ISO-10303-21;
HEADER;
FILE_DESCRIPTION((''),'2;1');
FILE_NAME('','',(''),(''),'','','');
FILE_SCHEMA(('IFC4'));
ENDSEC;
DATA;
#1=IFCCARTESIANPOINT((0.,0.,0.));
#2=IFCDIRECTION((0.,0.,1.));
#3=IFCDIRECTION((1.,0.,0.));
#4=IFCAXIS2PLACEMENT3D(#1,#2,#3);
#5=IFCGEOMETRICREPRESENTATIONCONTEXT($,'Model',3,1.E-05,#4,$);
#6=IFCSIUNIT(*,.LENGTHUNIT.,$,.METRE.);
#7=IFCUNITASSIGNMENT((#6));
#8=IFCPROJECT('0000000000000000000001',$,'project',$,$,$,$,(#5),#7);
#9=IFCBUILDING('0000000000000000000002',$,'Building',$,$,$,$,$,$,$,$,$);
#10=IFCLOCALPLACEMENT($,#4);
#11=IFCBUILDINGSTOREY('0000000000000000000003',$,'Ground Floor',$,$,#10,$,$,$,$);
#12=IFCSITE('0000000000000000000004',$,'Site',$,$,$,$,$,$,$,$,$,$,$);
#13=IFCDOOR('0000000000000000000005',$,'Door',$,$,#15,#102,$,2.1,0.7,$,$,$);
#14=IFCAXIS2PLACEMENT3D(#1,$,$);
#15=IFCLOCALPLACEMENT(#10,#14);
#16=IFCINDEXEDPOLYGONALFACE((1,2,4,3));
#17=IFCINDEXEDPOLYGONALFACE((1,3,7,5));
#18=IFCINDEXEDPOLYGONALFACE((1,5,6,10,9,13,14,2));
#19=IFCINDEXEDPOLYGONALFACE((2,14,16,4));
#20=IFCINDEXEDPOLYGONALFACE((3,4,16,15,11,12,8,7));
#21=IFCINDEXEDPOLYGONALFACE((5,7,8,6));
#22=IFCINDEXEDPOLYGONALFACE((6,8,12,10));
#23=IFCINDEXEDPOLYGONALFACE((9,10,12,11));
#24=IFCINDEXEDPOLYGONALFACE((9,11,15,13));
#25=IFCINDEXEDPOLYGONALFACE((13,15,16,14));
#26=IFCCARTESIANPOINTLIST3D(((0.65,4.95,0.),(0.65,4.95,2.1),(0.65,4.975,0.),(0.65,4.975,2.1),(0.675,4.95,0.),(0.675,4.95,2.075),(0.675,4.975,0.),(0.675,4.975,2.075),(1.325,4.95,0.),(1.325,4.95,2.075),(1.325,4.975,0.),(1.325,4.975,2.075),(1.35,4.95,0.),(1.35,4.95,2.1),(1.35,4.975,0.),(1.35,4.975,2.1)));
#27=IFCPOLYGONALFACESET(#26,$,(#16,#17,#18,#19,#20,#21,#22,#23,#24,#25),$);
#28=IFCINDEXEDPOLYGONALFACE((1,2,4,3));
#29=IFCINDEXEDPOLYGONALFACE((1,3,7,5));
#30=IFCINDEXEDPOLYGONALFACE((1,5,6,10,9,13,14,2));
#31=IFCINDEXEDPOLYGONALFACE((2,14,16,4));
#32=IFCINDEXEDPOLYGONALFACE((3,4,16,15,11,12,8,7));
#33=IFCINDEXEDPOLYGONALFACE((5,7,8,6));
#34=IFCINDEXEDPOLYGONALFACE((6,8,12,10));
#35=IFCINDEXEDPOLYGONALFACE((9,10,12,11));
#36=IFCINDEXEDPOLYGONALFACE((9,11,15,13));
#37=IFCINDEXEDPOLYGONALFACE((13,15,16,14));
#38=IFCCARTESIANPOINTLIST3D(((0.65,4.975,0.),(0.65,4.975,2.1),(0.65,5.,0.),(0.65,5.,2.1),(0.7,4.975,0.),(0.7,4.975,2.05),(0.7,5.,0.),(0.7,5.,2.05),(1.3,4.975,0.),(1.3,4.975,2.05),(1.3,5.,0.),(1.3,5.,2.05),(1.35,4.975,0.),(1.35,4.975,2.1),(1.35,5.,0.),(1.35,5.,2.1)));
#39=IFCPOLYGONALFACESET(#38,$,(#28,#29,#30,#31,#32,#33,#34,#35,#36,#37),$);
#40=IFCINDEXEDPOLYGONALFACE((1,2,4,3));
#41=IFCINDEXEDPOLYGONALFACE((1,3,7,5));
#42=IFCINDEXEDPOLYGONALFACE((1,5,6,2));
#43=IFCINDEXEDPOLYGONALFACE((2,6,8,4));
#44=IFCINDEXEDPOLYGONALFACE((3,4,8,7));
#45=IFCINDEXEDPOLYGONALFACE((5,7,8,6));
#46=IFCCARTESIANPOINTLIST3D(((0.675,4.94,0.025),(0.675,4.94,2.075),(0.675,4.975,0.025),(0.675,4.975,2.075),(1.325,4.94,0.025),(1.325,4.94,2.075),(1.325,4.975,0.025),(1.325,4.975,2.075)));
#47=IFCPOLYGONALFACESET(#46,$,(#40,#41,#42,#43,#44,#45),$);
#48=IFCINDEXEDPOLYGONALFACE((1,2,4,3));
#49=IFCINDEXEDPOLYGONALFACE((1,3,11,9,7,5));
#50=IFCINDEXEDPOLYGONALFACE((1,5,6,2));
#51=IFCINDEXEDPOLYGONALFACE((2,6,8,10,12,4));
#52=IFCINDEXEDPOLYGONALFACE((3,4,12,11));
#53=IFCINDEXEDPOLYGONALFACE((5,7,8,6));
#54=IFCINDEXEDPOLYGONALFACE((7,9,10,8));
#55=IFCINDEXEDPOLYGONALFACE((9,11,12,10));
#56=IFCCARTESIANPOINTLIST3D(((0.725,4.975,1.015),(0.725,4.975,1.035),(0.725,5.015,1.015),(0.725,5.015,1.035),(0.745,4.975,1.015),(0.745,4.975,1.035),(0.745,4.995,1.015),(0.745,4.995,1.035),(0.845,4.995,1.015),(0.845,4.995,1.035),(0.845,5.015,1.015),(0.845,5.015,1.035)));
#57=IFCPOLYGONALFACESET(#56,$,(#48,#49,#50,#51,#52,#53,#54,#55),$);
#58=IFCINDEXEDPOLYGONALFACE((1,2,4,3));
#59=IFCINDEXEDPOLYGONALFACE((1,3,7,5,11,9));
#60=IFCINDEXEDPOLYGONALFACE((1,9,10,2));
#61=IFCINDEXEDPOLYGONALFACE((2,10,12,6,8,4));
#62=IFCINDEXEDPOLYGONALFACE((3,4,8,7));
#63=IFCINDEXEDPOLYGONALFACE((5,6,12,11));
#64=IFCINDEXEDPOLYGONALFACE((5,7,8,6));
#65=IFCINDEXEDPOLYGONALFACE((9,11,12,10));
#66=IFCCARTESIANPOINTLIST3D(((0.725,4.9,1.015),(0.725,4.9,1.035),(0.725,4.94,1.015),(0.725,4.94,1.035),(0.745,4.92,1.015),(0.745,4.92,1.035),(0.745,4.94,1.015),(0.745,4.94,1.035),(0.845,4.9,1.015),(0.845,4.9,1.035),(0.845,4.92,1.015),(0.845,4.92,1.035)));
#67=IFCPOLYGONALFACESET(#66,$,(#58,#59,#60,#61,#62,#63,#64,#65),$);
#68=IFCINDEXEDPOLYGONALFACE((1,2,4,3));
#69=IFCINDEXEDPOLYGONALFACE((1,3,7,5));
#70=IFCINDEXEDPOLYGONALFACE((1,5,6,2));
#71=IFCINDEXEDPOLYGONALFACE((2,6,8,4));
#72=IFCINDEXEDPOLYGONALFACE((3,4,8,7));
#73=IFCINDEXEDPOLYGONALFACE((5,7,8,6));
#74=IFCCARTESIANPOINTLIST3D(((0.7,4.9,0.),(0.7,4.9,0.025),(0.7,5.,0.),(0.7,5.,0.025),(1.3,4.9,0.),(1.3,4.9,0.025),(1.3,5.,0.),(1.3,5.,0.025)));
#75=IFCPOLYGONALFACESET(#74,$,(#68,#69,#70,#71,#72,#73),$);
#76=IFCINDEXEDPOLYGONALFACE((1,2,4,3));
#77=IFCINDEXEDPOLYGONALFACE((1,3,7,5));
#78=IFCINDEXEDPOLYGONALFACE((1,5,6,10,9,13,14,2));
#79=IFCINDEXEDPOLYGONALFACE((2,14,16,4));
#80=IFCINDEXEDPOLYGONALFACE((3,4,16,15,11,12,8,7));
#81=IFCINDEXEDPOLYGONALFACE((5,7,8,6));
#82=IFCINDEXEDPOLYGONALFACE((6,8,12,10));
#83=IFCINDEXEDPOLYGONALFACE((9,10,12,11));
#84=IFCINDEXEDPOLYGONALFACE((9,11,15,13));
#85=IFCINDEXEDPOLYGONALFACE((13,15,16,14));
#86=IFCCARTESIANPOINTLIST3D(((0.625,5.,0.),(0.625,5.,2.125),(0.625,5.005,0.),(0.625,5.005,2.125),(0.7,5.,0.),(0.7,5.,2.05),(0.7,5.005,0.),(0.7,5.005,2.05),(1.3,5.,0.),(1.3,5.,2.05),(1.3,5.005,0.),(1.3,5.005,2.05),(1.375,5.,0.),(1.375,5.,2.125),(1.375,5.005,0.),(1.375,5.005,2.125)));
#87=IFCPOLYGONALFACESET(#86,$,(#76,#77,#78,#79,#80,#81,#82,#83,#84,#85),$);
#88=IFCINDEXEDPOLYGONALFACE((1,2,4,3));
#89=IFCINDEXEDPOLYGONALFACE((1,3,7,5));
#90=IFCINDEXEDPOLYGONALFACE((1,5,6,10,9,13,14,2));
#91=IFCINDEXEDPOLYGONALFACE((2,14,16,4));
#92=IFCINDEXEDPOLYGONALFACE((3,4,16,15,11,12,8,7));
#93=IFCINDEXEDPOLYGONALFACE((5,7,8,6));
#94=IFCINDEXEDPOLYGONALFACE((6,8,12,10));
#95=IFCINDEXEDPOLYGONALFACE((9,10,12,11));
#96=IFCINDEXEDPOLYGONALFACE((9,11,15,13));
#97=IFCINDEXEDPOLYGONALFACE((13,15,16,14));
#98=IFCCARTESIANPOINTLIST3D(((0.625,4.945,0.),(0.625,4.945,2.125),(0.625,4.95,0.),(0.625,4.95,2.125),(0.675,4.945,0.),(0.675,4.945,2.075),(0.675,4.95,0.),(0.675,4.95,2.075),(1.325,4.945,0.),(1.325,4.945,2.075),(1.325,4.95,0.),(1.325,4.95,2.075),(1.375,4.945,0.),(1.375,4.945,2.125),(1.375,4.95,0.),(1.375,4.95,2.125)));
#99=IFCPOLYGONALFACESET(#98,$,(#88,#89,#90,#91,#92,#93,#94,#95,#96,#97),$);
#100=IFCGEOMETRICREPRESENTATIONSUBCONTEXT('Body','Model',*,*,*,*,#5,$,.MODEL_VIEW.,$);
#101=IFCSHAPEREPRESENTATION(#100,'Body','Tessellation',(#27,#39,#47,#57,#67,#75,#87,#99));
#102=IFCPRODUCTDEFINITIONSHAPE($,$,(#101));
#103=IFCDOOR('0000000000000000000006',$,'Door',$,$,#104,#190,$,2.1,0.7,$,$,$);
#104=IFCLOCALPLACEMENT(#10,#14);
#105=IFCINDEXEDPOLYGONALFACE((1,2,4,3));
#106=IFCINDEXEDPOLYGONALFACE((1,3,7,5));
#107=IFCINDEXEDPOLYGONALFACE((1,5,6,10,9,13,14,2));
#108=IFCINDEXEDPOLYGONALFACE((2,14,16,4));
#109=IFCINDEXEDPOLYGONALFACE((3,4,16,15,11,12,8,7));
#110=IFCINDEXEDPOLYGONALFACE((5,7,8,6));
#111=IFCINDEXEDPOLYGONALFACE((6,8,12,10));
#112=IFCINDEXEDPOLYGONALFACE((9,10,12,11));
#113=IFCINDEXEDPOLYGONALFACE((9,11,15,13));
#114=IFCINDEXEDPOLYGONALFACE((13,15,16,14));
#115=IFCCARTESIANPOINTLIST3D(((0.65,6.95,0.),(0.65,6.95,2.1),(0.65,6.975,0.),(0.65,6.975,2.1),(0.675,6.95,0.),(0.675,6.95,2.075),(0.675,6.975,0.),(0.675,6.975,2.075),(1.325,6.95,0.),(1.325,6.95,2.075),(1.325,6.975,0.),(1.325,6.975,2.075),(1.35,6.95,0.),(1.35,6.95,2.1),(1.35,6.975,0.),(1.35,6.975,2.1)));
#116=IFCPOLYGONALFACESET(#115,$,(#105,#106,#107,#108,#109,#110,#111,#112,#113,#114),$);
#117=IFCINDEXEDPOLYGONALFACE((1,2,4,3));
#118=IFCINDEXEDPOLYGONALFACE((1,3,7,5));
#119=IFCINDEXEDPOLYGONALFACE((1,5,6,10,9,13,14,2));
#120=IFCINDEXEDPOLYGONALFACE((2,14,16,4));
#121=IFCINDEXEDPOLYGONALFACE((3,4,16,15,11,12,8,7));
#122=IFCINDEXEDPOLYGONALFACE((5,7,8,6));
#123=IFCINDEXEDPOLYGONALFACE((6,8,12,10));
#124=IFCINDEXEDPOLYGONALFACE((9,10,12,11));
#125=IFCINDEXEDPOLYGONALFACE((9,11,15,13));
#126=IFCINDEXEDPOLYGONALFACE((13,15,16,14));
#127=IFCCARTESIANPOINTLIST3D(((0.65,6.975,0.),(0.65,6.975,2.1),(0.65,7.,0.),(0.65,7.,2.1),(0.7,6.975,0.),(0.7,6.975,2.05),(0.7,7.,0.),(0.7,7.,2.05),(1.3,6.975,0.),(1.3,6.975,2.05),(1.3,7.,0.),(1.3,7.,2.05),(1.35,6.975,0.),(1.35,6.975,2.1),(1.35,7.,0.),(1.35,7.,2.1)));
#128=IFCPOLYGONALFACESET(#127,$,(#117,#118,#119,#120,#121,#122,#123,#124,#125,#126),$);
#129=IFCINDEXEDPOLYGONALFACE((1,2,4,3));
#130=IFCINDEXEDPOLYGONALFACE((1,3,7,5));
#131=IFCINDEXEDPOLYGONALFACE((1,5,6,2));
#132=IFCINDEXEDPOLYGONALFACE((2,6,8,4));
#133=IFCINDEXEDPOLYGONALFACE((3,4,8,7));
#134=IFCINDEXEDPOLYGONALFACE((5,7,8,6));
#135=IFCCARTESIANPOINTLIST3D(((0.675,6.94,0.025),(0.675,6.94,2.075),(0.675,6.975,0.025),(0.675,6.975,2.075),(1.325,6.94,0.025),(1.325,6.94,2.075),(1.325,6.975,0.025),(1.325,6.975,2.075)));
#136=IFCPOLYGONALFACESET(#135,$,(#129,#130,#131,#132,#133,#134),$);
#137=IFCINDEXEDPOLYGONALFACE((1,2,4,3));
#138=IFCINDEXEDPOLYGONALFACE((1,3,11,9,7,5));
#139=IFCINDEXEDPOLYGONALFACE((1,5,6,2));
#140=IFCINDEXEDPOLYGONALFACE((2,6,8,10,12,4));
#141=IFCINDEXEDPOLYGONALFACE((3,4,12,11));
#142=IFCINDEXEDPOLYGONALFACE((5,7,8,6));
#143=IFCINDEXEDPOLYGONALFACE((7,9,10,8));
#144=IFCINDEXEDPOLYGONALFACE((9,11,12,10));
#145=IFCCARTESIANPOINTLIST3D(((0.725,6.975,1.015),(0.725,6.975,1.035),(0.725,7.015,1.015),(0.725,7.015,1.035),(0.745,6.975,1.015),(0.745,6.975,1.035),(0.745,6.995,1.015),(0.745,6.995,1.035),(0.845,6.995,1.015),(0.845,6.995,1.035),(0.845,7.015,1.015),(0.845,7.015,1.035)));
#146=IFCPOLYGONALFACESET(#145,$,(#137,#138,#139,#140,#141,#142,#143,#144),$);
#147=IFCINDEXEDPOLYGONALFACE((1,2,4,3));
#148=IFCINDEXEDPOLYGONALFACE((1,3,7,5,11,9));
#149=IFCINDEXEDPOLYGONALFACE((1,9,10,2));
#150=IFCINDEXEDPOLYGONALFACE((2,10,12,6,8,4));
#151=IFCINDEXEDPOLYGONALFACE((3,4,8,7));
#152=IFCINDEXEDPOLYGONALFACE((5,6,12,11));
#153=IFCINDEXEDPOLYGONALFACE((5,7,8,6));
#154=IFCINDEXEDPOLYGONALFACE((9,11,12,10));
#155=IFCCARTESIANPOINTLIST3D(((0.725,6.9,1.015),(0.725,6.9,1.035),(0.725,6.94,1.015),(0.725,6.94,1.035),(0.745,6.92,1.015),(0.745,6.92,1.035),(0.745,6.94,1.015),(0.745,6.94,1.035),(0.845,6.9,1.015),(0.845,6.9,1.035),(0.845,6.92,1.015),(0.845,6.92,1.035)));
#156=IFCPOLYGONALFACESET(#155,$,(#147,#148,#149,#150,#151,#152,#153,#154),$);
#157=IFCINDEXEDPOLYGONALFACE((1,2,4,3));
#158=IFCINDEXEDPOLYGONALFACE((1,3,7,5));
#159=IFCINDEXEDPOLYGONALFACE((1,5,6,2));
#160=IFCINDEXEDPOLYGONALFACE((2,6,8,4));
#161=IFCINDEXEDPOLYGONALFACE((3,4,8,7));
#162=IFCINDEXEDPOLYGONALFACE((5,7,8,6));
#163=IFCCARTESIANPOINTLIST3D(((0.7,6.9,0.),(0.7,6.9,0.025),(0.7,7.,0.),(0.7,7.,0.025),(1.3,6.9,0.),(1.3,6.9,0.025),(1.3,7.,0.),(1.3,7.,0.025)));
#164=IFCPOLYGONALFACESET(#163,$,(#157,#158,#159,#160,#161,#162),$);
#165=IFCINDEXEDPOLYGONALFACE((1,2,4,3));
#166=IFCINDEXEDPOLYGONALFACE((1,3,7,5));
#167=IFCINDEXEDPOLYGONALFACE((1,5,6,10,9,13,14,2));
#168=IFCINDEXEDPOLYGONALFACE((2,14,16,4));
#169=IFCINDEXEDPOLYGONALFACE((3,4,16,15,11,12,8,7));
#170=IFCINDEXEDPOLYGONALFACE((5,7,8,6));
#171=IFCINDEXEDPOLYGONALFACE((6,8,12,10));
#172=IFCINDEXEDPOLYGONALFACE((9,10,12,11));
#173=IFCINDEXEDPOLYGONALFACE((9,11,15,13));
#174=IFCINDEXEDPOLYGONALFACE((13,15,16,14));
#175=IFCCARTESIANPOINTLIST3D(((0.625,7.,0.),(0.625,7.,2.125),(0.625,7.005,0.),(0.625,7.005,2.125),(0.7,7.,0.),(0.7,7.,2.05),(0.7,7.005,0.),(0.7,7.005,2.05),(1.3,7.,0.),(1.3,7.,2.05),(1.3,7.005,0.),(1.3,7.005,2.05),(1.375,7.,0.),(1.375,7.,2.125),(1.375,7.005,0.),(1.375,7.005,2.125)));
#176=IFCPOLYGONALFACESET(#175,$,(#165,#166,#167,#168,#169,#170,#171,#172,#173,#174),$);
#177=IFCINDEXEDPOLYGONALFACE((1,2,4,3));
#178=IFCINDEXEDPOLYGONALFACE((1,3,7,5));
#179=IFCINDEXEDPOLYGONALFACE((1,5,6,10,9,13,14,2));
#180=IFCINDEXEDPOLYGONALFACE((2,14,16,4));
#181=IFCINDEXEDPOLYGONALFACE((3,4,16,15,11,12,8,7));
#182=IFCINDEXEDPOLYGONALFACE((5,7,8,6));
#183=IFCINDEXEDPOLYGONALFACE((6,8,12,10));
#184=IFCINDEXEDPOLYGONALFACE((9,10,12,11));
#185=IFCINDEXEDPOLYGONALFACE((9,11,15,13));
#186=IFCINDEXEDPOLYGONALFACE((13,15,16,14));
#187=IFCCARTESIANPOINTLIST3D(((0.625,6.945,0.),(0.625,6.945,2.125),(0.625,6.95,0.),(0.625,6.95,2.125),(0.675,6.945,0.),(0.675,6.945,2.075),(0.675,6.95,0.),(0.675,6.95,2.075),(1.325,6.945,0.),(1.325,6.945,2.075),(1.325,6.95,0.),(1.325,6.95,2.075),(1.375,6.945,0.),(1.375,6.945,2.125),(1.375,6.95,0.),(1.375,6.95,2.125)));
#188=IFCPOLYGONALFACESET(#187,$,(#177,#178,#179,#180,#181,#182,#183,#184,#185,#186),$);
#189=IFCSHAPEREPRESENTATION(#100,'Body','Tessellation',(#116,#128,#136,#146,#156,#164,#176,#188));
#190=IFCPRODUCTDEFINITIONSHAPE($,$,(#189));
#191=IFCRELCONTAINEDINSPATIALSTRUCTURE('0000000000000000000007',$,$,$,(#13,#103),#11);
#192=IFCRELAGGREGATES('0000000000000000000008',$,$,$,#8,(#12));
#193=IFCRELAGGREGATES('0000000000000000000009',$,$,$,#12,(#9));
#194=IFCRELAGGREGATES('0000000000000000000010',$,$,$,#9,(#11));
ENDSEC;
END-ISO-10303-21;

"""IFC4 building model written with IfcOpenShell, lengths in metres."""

from ifc_helpers import new_model, si_unit, frame, origin_with_axes, place, context, subcontext, project, spatial, line, indexed_curve, outline, extrude, element, save


model = new_model("IFC4")

# Units and contexts
model_context = context("Model", 3, precision=1e-05, world=origin_with_axes())
body_context = subcontext(model_context, "Body", "Model", "MODEL_VIEW")
ifc_project = project(units=[si_unit("LENGTHUNIT", "METRE")], contexts=[model_context])

# Site, building, storey
site = spatial("IfcSite", under=ifc_project, Name="Site")
building = spatial("IfcBuilding", under=site, Name="Building")
storey_placement = place(None, origin_with_axes())
storey = spatial("IfcBuildingStorey", under=building, at=storey_placement, Name="Ground Floor")

# Doors
door_1_placement = place(storey_placement, frame((1.35, 5.0, 0.0), z_axis=(0.0, 0.0, 1.0), x_axis=(-1.0, 0.0, 0.0)))
element("IfcDoor", 1, at=door_1_placement, inside=storey, Name="Door", OverallHeight=2.1, OverallWidth=0.7, context=body_context, shape_type="SweptSolid", body=[
    extrude(outline(indexed_curve([(0.0, 0.0), (0.0, 2.1), (0.7, 2.1), (0.7, 0.0), (0.675, 0.0), (0.675, 2.075), (0.025, 2.075), (0.025, 0.0)], segments=[line(1, 2, 3, 4, 5, 6, 7, 8, 1)])), frame((0.0, 0.025, 0.0), z_axis=(0.0, -1.0, 0.0), x_axis=(1.0, 0.0, 0.0)), (0.0, 0.0, -1.0), 0.025),
    extrude(outline(indexed_curve([(0.0, 0.0), (0.0, 2.1), (0.7, 2.1), (0.7, 0.0), (0.65, 0.0), (0.65, 2.05), (0.05, 2.05), (0.05, 0.0)], segments=[line(1, 2, 3, 4, 5, 6, 7, 8, 1)])), frame((0.0, 0.0, 0.0), z_axis=(0.0, -1.0, 0.0), x_axis=(1.0, 0.0, 0.0)), (0.0, 0.0, -1.0), 0.025),
    extrude(outline(indexed_curve([(0.0, 0.0), (0.65, 0.0), (0.65, 0.035), (0.0, 0.035)], segments=[line(1, 2, 3, 4, 1)])), frame((0.025, 0.025, 0.025), z_axis=(0.0, 0.0, 1.0), x_axis=(1.0, 0.0, 0.0)), (0.0, 0.0, 1.0), 2.05),
    extrude(outline(indexed_curve([(0.0, 0.0), (0.0, -0.04), (-0.12, -0.04), (-0.12, -0.02), (-0.02, -0.02), (-0.02, 0.0)], segments=[line(1, 2, 3, 4, 5, 6, 1)])), frame((0.625, 0.025, 1.015), z_axis=(0.0, 0.0, 1.0), x_axis=(1.0, 0.0, 0.0)), (0.0, 0.0, 1.0), 0.02),
    extrude(outline(indexed_curve([(0.0, 0.0), (0.0, 0.04), (-0.12, 0.04), (-0.12, 0.02), (-0.02, 0.02), (-0.02, 0.0)], segments=[line(1, 2, 3, 4, 5, 6, 1)])), frame((0.625, 0.06, 1.015), z_axis=(0.0, 0.0, 1.0), x_axis=(1.0, 0.0, 0.0)), (0.0, 0.0, 1.0), 0.02),
    extrude(outline(indexed_curve([(0.0, 0.0), (0.6, 0.0), (0.6, 0.1), (0.0, 0.1)], segments=[line(1, 2, 3, 4, 1)])), frame((0.05, 0.0, 0.0), z_axis=(0.0, 0.0, 1.0), x_axis=(1.0, 0.0, 0.0)), (0.0, 0.0, 1.0), 0.025),
    extrude(outline(indexed_curve([(0.0, 0.0), (0.0, 2.125), (0.75, 2.125), (0.75, 0.0), (0.675, 0.0), (0.675, 2.05), (0.075, 2.05), (0.075, 0.0)], segments=[line(1, 2, 3, 4, 5, 6, 7, 8, 1)])), frame((-0.025, -0.005, 0.0), z_axis=(0.0, -1.0, 0.0), x_axis=(1.0, 0.0, 0.0)), (0.0, 0.0, -1.0), 0.005),
    extrude(outline(indexed_curve([(0.0, 0.0), (0.0, 2.125), (0.75, 2.125), (0.75, 0.0), (0.7, 0.0), (0.7, 2.075), (0.05, 2.075), (0.05, 0.0)], segments=[line(1, 2, 3, 4, 5, 6, 7, 8, 1)])), frame((-0.025, 0.05, 0.0), z_axis=(0.0, -1.0, 0.0), x_axis=(1.0, 0.0, 0.0)), (0.0, 0.0, -1.0), 0.005),
])
door_2_placement = place(storey_placement, frame((1.35, 7.0, 0.0), z_axis=(0.0, 0.0, 1.0), x_axis=(-1.0, 0.0, 0.0)))
element("IfcDoor", 2, at=door_2_placement, inside=storey, Name="Door", OverallHeight=2.1, OverallWidth=0.7, context=body_context, shape_type="SweptSolid", body=[
    extrude(outline(indexed_curve([(0.0, 0.0), (0.0, 2.1), (0.7, 2.1), (0.7, 0.0), (0.675, 0.0), (0.675, 2.075), (0.025, 2.075), (0.025, 0.0)], segments=[line(1, 2, 3, 4, 5, 6, 7, 8, 1)])), frame((0.0, 0.025, 0.0), z_axis=(0.0, -1.0, 0.0), x_axis=(1.0, 0.0, 0.0)), (0.0, 0.0, -1.0), 0.025),
    extrude(outline(indexed_curve([(0.0, 0.0), (0.0, 2.1), (0.7, 2.1), (0.7, 0.0), (0.65, 0.0), (0.65, 2.05), (0.05, 2.05), (0.05, 0.0)], segments=[line(1, 2, 3, 4, 5, 6, 7, 8, 1)])), frame((0.0, 0.0, 0.0), z_axis=(0.0, -1.0, 0.0), x_axis=(1.0, 0.0, 0.0)), (0.0, 0.0, -1.0), 0.025),
    extrude(outline(indexed_curve([(0.0, 0.0), (0.65, 0.0), (0.65, 0.035), (0.0, 0.035)], segments=[line(1, 2, 3, 4, 1)])), frame((0.025, 0.025, 0.025), z_axis=(0.0, 0.0, 1.0), x_axis=(1.0, 0.0, 0.0)), (0.0, 0.0, 1.0), 2.05),
    extrude(outline(indexed_curve([(0.0, 0.0), (0.0, -0.04), (-0.12, -0.04), (-0.12, -0.02), (-0.02, -0.02), (-0.02, 0.0)], segments=[line(1, 2, 3, 4, 5, 6, 1)])), frame((0.625, 0.025, 1.015), z_axis=(0.0, 0.0, 1.0), x_axis=(1.0, 0.0, 0.0)), (0.0, 0.0, 1.0), 0.02),
    extrude(outline(indexed_curve([(0.0, 0.0), (0.0, 0.04), (-0.12, 0.04), (-0.12, 0.02), (-0.02, 0.02), (-0.02, 0.0)], segments=[line(1, 2, 3, 4, 5, 6, 1)])), frame((0.625, 0.06, 1.015), z_axis=(0.0, 0.0, 1.0), x_axis=(1.0, 0.0, 0.0)), (0.0, 0.0, 1.0), 0.02),
    extrude(outline(indexed_curve([(0.0, 0.0), (0.6, 0.0), (0.6, 0.1), (0.0, 0.1)], segments=[line(1, 2, 3, 4, 1)])), frame((0.05, 0.0, 0.0), z_axis=(0.0, 0.0, 1.0), x_axis=(1.0, 0.0, 0.0)), (0.0, 0.0, 1.0), 0.025),
    extrude(outline(indexed_curve([(0.0, 0.0), (0.0, 2.125), (0.75, 2.125), (0.75, 0.0), (0.675, 0.0), (0.675, 2.05), (0.075, 2.05), (0.075, 0.0)], segments=[line(1, 2, 3, 4, 5, 6, 7, 8, 1)])), frame((-0.025, -0.005, 0.0), z_axis=(0.0, -1.0, 0.0), x_axis=(1.0, 0.0, 0.0)), (0.0, 0.0, -1.0), 0.005),
    extrude(outline(indexed_curve([(0.0, 0.0), (0.0, 2.125), (0.75, 2.125), (0.75, 0.0), (0.7, 0.0), (0.7, 2.075), (0.05, 2.075), (0.05, 0.0)], segments=[line(1, 2, 3, 4, 5, 6, 7, 8, 1)])), frame((-0.025, 0.05, 0.0), z_axis=(0.0, -1.0, 0.0), x_axis=(1.0, 0.0, 0.0)), (0.0, 0.0, -1.0), 0.005),
])

save(model, "model.ifc")
